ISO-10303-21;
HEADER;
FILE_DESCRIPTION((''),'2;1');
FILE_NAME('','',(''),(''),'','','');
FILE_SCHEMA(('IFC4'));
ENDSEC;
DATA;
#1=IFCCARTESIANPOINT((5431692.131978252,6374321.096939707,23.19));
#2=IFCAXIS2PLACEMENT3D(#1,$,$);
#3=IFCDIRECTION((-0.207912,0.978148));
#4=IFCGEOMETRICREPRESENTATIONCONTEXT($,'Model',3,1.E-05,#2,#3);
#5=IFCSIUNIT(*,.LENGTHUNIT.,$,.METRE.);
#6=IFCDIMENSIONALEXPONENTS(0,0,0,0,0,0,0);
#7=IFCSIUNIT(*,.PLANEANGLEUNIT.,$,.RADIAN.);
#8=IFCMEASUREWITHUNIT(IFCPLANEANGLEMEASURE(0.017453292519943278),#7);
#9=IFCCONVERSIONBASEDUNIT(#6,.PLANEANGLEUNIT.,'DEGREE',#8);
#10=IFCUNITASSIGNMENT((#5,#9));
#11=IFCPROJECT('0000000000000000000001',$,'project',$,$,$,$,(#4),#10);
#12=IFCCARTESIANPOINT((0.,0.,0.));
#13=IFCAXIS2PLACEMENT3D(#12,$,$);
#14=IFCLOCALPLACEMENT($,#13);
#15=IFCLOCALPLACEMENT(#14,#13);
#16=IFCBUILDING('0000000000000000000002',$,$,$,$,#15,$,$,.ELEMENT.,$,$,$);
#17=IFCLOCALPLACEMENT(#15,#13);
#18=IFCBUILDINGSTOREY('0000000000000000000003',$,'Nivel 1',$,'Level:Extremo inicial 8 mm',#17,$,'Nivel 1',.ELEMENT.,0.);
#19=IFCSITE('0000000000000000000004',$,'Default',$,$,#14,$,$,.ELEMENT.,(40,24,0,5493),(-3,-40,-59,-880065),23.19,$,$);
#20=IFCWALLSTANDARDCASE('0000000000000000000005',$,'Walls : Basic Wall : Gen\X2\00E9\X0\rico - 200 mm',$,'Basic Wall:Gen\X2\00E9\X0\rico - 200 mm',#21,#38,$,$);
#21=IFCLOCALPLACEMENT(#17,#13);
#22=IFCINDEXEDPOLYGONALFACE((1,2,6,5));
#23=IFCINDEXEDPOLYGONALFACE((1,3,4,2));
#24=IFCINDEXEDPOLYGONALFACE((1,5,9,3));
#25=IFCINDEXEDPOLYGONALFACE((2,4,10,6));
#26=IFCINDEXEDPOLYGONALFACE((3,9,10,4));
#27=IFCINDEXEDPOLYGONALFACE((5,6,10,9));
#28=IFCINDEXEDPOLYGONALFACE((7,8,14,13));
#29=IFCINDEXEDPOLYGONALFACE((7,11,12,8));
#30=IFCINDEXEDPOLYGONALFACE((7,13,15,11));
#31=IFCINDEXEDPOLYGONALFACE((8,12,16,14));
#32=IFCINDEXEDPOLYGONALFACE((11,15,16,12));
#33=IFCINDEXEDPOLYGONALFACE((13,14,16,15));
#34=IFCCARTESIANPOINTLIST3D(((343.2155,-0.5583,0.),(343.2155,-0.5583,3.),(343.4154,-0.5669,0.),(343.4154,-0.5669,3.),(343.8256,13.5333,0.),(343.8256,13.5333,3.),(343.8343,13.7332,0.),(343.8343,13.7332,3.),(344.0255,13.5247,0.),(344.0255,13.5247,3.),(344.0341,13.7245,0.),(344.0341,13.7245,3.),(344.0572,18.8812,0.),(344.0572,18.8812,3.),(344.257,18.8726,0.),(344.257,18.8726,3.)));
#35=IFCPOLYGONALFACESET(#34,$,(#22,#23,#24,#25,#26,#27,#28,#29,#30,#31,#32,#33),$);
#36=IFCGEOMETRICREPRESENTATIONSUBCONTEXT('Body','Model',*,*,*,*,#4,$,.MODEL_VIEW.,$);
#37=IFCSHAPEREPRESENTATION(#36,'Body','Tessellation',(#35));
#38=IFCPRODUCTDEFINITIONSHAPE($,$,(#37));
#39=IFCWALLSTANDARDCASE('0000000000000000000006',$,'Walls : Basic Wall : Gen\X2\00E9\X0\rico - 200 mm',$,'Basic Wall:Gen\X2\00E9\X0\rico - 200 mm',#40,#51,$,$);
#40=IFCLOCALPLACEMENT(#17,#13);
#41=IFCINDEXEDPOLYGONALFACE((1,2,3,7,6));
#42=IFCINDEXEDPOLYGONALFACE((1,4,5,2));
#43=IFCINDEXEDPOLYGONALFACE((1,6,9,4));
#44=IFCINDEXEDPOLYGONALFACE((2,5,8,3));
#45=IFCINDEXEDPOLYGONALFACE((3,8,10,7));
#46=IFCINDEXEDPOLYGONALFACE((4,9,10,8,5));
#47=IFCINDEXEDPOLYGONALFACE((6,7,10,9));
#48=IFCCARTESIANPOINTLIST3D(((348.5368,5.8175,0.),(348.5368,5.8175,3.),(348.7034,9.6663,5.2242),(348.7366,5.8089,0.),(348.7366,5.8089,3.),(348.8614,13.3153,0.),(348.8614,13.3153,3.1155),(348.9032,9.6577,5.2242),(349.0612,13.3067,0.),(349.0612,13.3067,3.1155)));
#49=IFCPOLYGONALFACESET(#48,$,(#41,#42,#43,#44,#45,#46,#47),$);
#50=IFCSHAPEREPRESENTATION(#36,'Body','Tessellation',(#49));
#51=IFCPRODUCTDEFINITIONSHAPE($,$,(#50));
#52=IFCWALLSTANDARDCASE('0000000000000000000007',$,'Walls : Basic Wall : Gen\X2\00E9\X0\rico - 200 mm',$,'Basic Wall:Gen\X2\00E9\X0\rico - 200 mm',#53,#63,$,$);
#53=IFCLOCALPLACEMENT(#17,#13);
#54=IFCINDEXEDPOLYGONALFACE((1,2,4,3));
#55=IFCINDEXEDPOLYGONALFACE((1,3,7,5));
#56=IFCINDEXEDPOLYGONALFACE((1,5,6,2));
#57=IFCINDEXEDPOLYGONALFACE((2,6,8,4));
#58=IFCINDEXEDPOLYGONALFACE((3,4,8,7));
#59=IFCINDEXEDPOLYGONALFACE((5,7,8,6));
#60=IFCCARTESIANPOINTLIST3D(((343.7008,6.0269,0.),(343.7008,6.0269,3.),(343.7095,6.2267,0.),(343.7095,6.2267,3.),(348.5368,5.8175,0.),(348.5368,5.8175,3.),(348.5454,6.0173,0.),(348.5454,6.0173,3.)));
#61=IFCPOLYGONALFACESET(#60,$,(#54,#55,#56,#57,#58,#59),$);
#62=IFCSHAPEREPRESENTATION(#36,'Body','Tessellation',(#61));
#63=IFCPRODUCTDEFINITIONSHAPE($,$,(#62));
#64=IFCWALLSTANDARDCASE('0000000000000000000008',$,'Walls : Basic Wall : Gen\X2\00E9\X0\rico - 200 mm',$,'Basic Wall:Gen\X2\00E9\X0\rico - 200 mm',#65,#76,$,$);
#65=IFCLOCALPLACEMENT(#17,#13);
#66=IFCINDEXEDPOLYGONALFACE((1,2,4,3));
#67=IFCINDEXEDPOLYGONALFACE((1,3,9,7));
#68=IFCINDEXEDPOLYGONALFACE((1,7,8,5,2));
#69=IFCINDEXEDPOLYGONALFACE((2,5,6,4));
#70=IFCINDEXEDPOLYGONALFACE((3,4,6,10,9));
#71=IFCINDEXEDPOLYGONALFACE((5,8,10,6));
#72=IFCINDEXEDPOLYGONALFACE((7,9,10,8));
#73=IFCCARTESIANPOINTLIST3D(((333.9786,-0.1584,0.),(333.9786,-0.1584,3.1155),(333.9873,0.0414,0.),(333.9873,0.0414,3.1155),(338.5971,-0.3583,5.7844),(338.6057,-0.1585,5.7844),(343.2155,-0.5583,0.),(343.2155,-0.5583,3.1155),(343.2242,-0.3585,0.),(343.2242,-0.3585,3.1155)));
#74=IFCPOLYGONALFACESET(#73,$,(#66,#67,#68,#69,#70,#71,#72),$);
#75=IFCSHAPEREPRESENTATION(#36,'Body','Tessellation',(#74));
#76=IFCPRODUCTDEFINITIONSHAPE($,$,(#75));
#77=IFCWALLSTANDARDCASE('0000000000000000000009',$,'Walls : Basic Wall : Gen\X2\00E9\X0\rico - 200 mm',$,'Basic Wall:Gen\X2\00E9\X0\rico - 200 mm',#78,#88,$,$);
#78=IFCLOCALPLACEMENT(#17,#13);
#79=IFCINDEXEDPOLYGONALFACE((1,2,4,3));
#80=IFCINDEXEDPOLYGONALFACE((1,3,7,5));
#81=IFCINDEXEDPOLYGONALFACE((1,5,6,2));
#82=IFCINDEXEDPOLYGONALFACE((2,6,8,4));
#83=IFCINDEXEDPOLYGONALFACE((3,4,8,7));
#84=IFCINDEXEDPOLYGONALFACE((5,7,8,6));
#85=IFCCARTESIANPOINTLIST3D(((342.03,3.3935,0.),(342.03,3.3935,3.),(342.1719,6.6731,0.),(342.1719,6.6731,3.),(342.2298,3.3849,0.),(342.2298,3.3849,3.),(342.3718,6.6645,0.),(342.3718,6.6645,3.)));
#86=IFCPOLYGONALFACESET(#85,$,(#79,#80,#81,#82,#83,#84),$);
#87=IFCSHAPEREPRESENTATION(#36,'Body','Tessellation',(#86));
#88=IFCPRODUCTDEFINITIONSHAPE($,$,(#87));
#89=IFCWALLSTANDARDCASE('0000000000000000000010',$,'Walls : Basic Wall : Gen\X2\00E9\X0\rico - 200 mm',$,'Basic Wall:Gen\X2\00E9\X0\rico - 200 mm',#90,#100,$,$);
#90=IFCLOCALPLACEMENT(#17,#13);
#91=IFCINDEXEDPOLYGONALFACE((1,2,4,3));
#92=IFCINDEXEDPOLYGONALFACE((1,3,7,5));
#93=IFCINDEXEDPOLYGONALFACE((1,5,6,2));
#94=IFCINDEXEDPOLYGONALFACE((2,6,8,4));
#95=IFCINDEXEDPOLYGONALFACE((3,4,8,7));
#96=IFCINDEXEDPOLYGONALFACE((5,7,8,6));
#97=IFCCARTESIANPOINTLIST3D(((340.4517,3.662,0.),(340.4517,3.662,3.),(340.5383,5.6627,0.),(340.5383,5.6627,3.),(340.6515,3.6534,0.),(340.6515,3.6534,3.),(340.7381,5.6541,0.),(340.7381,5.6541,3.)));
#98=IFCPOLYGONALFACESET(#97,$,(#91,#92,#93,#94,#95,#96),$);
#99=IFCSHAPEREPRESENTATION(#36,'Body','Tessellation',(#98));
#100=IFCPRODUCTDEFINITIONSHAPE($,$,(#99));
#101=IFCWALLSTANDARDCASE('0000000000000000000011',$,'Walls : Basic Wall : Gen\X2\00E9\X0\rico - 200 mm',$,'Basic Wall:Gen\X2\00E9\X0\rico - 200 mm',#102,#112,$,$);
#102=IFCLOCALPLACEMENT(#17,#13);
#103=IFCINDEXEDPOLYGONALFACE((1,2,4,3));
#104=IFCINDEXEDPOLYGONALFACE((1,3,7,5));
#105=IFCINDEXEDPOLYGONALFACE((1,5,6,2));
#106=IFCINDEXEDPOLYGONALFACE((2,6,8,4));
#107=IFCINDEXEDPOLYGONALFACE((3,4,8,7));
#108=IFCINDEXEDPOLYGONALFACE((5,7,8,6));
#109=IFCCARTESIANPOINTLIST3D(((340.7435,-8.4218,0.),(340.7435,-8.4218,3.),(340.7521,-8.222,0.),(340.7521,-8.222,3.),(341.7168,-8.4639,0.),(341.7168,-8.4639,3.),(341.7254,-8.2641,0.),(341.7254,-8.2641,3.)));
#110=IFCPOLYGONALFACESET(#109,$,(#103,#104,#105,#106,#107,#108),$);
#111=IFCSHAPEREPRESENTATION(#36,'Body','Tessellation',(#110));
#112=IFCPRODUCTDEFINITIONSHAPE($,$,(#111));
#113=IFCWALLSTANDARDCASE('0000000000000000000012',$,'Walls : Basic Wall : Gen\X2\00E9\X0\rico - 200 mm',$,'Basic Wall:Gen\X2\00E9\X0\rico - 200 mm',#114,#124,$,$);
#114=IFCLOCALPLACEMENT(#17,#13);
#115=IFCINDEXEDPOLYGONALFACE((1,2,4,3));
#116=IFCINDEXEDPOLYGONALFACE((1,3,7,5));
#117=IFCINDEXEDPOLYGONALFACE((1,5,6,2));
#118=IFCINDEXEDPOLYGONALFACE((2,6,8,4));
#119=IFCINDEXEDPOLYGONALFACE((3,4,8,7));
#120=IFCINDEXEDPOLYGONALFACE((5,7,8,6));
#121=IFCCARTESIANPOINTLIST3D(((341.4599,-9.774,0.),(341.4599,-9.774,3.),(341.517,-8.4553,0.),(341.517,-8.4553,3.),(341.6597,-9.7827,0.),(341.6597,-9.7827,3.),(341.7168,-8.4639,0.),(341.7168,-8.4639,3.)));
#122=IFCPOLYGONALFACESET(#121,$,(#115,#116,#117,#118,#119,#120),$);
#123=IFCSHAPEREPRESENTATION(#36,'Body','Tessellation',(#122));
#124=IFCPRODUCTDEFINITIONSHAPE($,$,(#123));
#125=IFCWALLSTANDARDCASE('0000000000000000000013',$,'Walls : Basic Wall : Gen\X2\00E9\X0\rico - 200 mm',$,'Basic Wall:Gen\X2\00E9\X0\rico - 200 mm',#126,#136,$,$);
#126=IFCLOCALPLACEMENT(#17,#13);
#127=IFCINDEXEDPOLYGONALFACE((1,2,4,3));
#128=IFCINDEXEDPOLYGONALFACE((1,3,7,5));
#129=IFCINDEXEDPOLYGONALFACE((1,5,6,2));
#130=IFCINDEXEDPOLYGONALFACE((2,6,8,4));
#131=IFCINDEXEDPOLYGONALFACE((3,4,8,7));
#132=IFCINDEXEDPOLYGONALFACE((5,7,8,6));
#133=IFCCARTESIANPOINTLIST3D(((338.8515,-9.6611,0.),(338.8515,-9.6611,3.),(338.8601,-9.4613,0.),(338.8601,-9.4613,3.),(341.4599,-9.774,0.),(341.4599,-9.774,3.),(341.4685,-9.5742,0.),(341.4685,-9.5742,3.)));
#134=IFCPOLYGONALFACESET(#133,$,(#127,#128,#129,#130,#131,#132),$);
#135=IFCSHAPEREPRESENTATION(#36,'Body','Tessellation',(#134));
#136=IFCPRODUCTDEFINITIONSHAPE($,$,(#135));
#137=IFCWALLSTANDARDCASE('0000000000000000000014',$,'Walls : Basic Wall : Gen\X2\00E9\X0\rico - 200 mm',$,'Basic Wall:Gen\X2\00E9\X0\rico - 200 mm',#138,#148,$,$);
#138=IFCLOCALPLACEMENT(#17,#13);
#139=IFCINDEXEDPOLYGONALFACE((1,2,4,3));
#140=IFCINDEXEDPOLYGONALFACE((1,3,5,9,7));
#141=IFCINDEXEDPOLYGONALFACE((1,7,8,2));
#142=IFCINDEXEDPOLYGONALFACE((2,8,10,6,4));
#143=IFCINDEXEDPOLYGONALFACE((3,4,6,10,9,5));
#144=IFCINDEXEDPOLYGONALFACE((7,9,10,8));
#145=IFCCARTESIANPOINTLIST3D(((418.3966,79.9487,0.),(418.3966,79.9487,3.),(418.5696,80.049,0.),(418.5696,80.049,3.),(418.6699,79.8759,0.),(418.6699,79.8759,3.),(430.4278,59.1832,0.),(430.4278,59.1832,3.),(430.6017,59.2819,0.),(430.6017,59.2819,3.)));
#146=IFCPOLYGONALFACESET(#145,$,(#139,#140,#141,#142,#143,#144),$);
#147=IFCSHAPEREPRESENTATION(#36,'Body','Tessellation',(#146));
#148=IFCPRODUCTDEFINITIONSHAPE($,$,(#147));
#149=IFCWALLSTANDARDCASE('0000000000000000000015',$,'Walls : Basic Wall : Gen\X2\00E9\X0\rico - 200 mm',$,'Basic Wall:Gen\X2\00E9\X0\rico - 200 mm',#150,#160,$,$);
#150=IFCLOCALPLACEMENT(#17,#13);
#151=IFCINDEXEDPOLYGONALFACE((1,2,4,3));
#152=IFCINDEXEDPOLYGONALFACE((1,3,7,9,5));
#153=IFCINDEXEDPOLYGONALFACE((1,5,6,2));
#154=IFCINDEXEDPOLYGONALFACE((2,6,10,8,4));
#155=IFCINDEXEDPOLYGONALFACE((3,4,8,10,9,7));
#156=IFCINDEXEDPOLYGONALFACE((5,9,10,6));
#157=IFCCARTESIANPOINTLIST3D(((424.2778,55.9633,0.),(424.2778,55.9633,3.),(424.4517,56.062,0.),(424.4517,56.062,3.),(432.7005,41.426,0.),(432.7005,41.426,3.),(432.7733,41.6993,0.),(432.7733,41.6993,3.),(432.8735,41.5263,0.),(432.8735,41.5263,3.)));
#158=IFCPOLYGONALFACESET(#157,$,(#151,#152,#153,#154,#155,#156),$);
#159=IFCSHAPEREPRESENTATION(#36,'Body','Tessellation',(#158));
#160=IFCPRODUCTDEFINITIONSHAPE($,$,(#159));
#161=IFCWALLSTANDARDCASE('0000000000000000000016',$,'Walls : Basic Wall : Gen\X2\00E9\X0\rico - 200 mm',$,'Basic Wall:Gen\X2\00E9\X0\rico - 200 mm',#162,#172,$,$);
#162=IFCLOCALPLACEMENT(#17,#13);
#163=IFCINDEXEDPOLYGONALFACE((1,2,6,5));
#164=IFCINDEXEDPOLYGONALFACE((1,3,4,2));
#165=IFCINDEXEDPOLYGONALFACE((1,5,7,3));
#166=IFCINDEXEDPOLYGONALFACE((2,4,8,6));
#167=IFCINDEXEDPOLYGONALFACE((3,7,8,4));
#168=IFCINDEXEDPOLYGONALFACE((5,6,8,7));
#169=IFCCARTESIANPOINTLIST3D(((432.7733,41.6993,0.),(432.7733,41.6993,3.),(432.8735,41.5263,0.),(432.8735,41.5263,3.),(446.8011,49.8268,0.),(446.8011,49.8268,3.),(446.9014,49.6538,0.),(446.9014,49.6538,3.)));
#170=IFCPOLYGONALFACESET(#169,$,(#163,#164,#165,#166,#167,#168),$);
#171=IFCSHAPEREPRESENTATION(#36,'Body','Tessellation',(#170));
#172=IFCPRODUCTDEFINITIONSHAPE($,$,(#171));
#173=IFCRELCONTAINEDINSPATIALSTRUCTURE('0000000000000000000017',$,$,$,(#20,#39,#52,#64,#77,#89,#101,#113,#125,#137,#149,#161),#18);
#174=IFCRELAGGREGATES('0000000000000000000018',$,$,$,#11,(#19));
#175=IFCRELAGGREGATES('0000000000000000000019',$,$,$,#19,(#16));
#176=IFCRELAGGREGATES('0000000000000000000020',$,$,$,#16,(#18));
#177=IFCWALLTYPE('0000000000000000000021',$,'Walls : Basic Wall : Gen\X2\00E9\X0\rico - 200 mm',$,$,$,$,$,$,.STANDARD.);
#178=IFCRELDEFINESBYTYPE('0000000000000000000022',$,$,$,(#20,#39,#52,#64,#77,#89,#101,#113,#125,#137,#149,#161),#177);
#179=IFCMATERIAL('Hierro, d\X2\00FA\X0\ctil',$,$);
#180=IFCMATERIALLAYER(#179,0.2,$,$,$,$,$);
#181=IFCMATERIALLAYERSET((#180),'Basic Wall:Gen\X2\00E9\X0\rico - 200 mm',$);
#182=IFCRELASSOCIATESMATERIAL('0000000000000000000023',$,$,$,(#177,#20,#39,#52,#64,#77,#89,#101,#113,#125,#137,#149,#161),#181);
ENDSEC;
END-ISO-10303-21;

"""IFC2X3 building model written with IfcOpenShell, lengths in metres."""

from ifc_helpers import new_model, entity, si_unit, converted_unit, direction, frame, frame_2d, origin, place, context, subcontext, project, spatial, polyline, rectangle, outline, extrude, clip, bounded_halfspace, material, layer, layer_set, layer_usage, type_object, element, save


model = new_model("IFC2X3")

# Units and contexts
model_context = context("Model", 3, precision=1e-05, world=frame((5431692.131978252, 6374321.096939707, 23.19)), true_north=direction((-0.207912, 0.978148)))
body_context = subcontext(model_context, "Body", "Model", "MODEL_VIEW")
ifc_project = project(units=[si_unit("LENGTHUNIT", "METRE"), converted_unit("PLANEANGLEUNIT", "DEGREE", entity("IfcPlaneAngleMeasure", 0.017453292519943278), si_unit("PLANEANGLEUNIT", "RADIAN"), dimensions=[0, 0, 0, 0, 0, 0, 0])], contexts=[model_context])

# Site, building, storey
site_placement = place(None, origin())
site = spatial("IfcSite", under=ifc_project, at=site_placement, Name="Default", CompositionType="ELEMENT", RefLatitude=(40, 24, 0, 5493), RefLongitude=(-3, -40, -59, -880065), RefElevation=23.19)
building_placement = place(site_placement, origin())
building = spatial("IfcBuilding", under=site, at=building_placement, CompositionType="ELEMENT")
storey_placement = place(building_placement, origin())
storey = spatial("IfcBuildingStorey", under=building, at=storey_placement, Name="Nivel 1", ObjectType="Level:Extremo inicial 8 mm", LongName="Nivel 1", CompositionType="ELEMENT", Elevation=0.0)

# Shared definitions
ifc_material_1 = material(Name="Hierro, dúctil")
ifc_layer_1 = layer(ifc_material_1, 0.2)
ifc_layer_set_1 = layer_set([ifc_layer_1], Name="Basic Wall:Genérico - 200 mm")
wall_type = type_object("IfcWallType", Name="Walls : Basic Wall : Genérico - 200 mm", PredefinedType="STANDARD", material=ifc_layer_set_1)

# Wall, opening
ifc_layer_usage_1 = layer_usage(ifc_layer_set_1, "AXIS2", "NEGATIVE", 0.1)
wall_1_placement = place(storey_placement, frame((344.1571, 18.8769, 0.0), z_axis=(0.0, 0.0, 1.0), x_axis=(-0.043255, -0.999064, 0.0)))
wall_1 = element("IfcWallStandardCase", 1, at=wall_1_placement, inside=storey, type_object=wall_type, material=ifc_layer_usage_1, Name="Walls : Basic Wall : Genérico - 200 mm", ObjectType="Basic Wall:Genérico - 200 mm", context=body_context, shape_type="SweptSolid", body=[
    extrude(rectangle(XDim=19.4577, YDim=0.2, at=frame_2d((9.7289, 0.0), x_axis=(-1.0, 0.0))), origin(), (0.0, 0.0, 1.0), 3.0),
])
opening_placement = place(storey_placement, frame((344.1571, 18.8769, 0.0), z_axis=(0.0, 0.0, 1.0), x_axis=(-0.043255, -0.999064, 0.0)))
element("IfcOpeningElement", 2, at=opening_placement, cuts=wall_1, ObjectType="Opening", context=body_context, shape_type="SweptSolid", body=[
    extrude(rectangle(XDim=3.0, YDim=0.2, at=frame_2d((0.0, 0.0), x_axis=(1.0, 0.0))), frame((5.3529, 0.0, 1.5), z_axis=(-1.0, 0.0, 0.0), x_axis=(0.0, 0.0, 1.0)), (0.0, 0.0, 1.0), 0.2),
])

# Walls
ifc_layer_usage_2 = layer_usage(ifc_layer_set_1, "AXIS2", "NEGATIVE", 0.1)
wall_2_placement = place(storey_placement, frame((348.9613, 13.311, 0.0), z_axis=(0.0, 0.0, 1.0), x_axis=(-0.043255, -0.999064, 0.0)))
element("IfcWallStandardCase", 3, at=wall_2_placement, inside=storey, type_object=wall_type, material=ifc_layer_usage_2, Name="Walls : Basic Wall : Genérico - 200 mm", ObjectType="Basic Wall:Genérico - 200 mm", context=body_context, shape_type="Clipping", body=[
    clip(clip(extrude(rectangle(XDim=7.5048, YDim=0.2, at=frame_2d((3.7524, 0.0), x_axis=(-1.0, 0.0))), origin(), (0.0, 0.0, 1.0), 5.2242), bounded_halfspace(frame((0.0, -0.1, 3.1155), z_axis=(-0.5, 0.0, 0.866025), x_axis=(0.0, -1.0, 0.0)), False, frame((0.0, -0.1, 3.1155)), polyline([(0.0, 0.0), (3.6524, 0.0), (3.6524, 0.2), (0.0, 0.2), (0.0, 0.0)]))), bounded_halfspace(frame((3.6524, -0.1, 5.2242), z_axis=(0.5, 0.0, 0.866025), x_axis=(0.0, 1.0, 0.0)), False, frame((3.6524, -0.1, 5.2242)), polyline([(0.0, 0.0), (3.8524, 0.0), (3.8524, 0.2), (0.0, 0.2), (0.0, 0.0)]))),
])
ifc_layer_usage_3 = layer_usage(ifc_layer_set_1, "AXIS2", "NEGATIVE", 0.1)
wall_3_placement = place(storey_placement, frame((348.5411, 5.9174, 0.0), z_axis=(0.0, 0.0, 1.0), x_axis=(-0.999064, 0.043255, 0.0)))
element("IfcWallStandardCase", 4, at=wall_3_placement, inside=storey, type_object=wall_type, material=ifc_layer_usage_3, Name="Walls : Basic Wall : Genérico - 200 mm", ObjectType="Basic Wall:Genérico - 200 mm", context=body_context, shape_type="SweptSolid", body=[
    extrude(rectangle(XDim=4.8405, YDim=0.2, at=frame_2d((2.4202, 0.0), x_axis=(-1.0, 0.0))), origin(), (0.0, 0.0, 1.0), 3.0),
])
ifc_layer_usage_4 = layer_usage(ifc_layer_set_1, "AXIS2", "NEGATIVE", 0.1)
wall_4_placement = place(storey_placement, frame((343.2199, -0.4584, 0.0), z_axis=(0.0, 0.0, 1.0), x_axis=(-0.999064, 0.043255, 0.0)))
element("IfcWallStandardCase", 5, at=wall_4_placement, inside=storey, type_object=wall_type, material=ifc_layer_usage_4, Name="Walls : Basic Wall : Genérico - 200 mm", ObjectType="Basic Wall:Genérico - 200 mm", context=body_context, shape_type="Clipping", body=[
    clip(clip(extrude(rectangle(XDim=9.2456, YDim=0.2, at=frame_2d((4.6228, 0.0), x_axis=(-1.0, 0.0))), origin(), (0.0, 0.0, 1.0), 5.7844), bounded_halfspace(frame((0.0, -0.1, 3.1155), z_axis=(-0.5, 0.0, 0.866025), x_axis=(0.0, -1.0, 0.0)), False, frame((0.0, -0.1, 3.1155)), polyline([(0.0, 0.0), (4.6228, 0.0), (4.6228, 0.2), (0.0, 0.2), (0.0, 0.0)]))), bounded_halfspace(frame((4.6228, -0.1, 5.7844), z_axis=(0.5, 0.0, 0.866025), x_axis=(0.0, 1.0, 0.0)), False, frame((4.6228, -0.1, 5.7844)), polyline([(0.0, 0.0), (4.6228, 0.0), (4.6228, 0.2), (0.0, 0.2), (0.0, 0.0)]))),
])
ifc_layer_usage_5 = layer_usage(ifc_layer_set_1, "AXIS2", "NEGATIVE", 0.1)
wall_5_placement = place(storey_placement, frame((342.2718, 6.6688, 0.0), z_axis=(0.0, 0.0, 1.0), x_axis=(-0.043255, -0.999064, 0.0)))
element("IfcWallStandardCase", 6, at=wall_5_placement, inside=storey, type_object=wall_type, material=ifc_layer_usage_5, Name="Walls : Basic Wall : Genérico - 200 mm", ObjectType="Basic Wall:Genérico - 200 mm", context=body_context, shape_type="SweptSolid", body=[
    extrude(rectangle(XDim=3.2827, YDim=0.2, at=frame_2d((1.6413, 0.0), x_axis=(-1.0, 0.0))), origin(), (0.0, 0.0, 1.0), 3.0),
])
ifc_layer_usage_6 = layer_usage(ifc_layer_set_1, "AXIS2", "NEGATIVE", 0.1)
wall_6_placement = place(storey_placement, frame((340.6382, 5.6584, 0.0), z_axis=(0.0, 0.0, 1.0), x_axis=(-0.043255, -0.999064, 0.0)))
element("IfcWallStandardCase", 7, at=wall_6_placement, inside=storey, type_object=wall_type, material=ifc_layer_usage_6, Name="Walls : Basic Wall : Genérico - 200 mm", ObjectType="Basic Wall:Genérico - 200 mm", context=body_context, shape_type="SweptSolid", body=[
    extrude(rectangle(XDim=2.0026, YDim=0.2, at=frame_2d((1.0013, 0.0), x_axis=(-1.0, 0.0))), origin(), (0.0, 0.0, 1.0), 3.0),
])
ifc_layer_usage_7 = layer_usage(ifc_layer_set_1, "AXIS2", "NEGATIVE", 0.1)
wall_7_placement = place(storey_placement, frame((340.7478, -8.3219, 0.0), z_axis=(0.0, 0.0, 1.0), x_axis=(0.999064, -0.043255, 0.0)))
element("IfcWallStandardCase", 8, at=wall_7_placement, inside=storey, type_object=wall_type, material=ifc_layer_usage_7, Name="Walls : Basic Wall : Genérico - 200 mm", ObjectType="Basic Wall:Genérico - 200 mm", context=body_context, shape_type="SweptSolid", body=[
    extrude(rectangle(XDim=0.9742, YDim=0.2, at=frame_2d((0.4871, 0.0), x_axis=(-1.0, 0.0))), origin(), (0.0, 0.0, 1.0), 3.0),
])
ifc_layer_usage_8 = layer_usage(ifc_layer_set_1, "AXIS2", "NEGATIVE", 0.1)
wall_8_placement = place(storey_placement, frame((341.6169, -8.4596, 0.0), z_axis=(0.0, 0.0, 1.0), x_axis=(-0.043255, -0.999064, 0.0)))
element("IfcWallStandardCase", 9, at=wall_8_placement, inside=storey, type_object=wall_type, material=ifc_layer_usage_8, Name="Walls : Basic Wall : Genérico - 200 mm", ObjectType="Basic Wall:Genérico - 200 mm", context=body_context, shape_type="SweptSolid", body=[
    extrude(rectangle(XDim=1.32, YDim=0.2, at=frame_2d((0.66, 0.0), x_axis=(-1.0, 0.0))), origin(), (0.0, 0.0, 1.0), 3.0),
])
ifc_layer_usage_9 = layer_usage(ifc_layer_set_1, "AXIS2", "NEGATIVE", 0.1)
wall_9_placement = place(storey_placement, frame((341.4642, -9.6741, 0.0), z_axis=(0.0, 0.0, 1.0), x_axis=(-0.999064, 0.043255, 0.0)))
element("IfcWallStandardCase", 10, at=wall_9_placement, inside=storey, type_object=wall_type, material=ifc_layer_usage_9, Name="Walls : Basic Wall : Genérico - 200 mm", ObjectType="Basic Wall:Genérico - 200 mm", context=body_context, shape_type="SweptSolid", body=[
    extrude(rectangle(XDim=2.6108, YDim=0.2, at=frame_2d((1.3054, 0.0), x_axis=(-1.0, 0.0))), origin(), (0.0, 0.0, 1.0), 3.0),
])
ifc_layer_usage_10 = layer_usage(ifc_layer_set_1, "AXIS2", "NEGATIVE", 0.1)
wall_10_placement = place(storey_placement, frame((430.5152, 59.2318, 0.0), z_axis=(0.0, 0.0, 1.0), x_axis=(-0.50132, 0.865262, 0.0)))
element("IfcWallStandardCase", 11, at=wall_10_placement, inside=storey, type_object=wall_type, material=ifc_layer_usage_10, Name="Walls : Basic Wall : Genérico - 200 mm", ObjectType="Basic Wall:Genérico - 200 mm", context=body_context, shape_type="SweptSolid", body=[
    extrude(outline(polyline([(24.0009, -0.1), (24.0009, 0.1), (0.0017, 0.1), (0.0, -0.1), (23.8009, -0.1), (24.0009, -0.1)])), origin(), (0.0, 0.0, 1.0), 3.0),
])
ifc_layer_usage_11 = layer_usage(ifc_layer_set_1, "AXIS2", "NEGATIVE", 0.1)
wall_11_placement = place(storey_placement, frame((424.3643, 56.0134, 0.0), z_axis=(0.0, 0.0, 1.0), x_axis=(0.50132, -0.865262, 0.0)))
element("IfcWallStandardCase", 12, at=wall_11_placement, inside=storey, type_object=wall_type, material=ifc_layer_usage_11, Name="Walls : Basic Wall : Genérico - 200 mm", ObjectType="Basic Wall:Genérico - 200 mm", context=body_context, shape_type="SweptSolid", body=[
    extrude(outline(polyline([(16.801, -0.1), (16.801, 0.1), (16.601, 0.1), (0.0017, 0.1), (0.0, -0.1), (16.801, -0.1)])), origin(), (0.0, 0.0, 1.0), 3.0),
])
ifc_layer_usage_12 = layer_usage(ifc_layer_set_1, "AXIS2", "NEGATIVE", 0.1)
wall_12_placement = place(storey_placement, frame((432.8234, 41.6128, 0.0), z_axis=(0.0, 0.0, 1.0), x_axis=(0.865262, 0.50132, 0.0)))
element("IfcWallStandardCase", 13, at=wall_12_placement, inside=storey, type_object=wall_type, material=ifc_layer_usage_12, Name="Walls : Basic Wall : Genérico - 200 mm", ObjectType="Basic Wall:Genérico - 200 mm", context=body_context, shape_type="SweptSolid", body=[
    extrude(rectangle(XDim=16.2122, YDim=0.2, at=frame_2d((8.1061, 0.0), x_axis=(-1.0, 0.0))), origin(), (0.0, 0.0, 1.0), 3.0),
])

save(model, "model.ifc")
